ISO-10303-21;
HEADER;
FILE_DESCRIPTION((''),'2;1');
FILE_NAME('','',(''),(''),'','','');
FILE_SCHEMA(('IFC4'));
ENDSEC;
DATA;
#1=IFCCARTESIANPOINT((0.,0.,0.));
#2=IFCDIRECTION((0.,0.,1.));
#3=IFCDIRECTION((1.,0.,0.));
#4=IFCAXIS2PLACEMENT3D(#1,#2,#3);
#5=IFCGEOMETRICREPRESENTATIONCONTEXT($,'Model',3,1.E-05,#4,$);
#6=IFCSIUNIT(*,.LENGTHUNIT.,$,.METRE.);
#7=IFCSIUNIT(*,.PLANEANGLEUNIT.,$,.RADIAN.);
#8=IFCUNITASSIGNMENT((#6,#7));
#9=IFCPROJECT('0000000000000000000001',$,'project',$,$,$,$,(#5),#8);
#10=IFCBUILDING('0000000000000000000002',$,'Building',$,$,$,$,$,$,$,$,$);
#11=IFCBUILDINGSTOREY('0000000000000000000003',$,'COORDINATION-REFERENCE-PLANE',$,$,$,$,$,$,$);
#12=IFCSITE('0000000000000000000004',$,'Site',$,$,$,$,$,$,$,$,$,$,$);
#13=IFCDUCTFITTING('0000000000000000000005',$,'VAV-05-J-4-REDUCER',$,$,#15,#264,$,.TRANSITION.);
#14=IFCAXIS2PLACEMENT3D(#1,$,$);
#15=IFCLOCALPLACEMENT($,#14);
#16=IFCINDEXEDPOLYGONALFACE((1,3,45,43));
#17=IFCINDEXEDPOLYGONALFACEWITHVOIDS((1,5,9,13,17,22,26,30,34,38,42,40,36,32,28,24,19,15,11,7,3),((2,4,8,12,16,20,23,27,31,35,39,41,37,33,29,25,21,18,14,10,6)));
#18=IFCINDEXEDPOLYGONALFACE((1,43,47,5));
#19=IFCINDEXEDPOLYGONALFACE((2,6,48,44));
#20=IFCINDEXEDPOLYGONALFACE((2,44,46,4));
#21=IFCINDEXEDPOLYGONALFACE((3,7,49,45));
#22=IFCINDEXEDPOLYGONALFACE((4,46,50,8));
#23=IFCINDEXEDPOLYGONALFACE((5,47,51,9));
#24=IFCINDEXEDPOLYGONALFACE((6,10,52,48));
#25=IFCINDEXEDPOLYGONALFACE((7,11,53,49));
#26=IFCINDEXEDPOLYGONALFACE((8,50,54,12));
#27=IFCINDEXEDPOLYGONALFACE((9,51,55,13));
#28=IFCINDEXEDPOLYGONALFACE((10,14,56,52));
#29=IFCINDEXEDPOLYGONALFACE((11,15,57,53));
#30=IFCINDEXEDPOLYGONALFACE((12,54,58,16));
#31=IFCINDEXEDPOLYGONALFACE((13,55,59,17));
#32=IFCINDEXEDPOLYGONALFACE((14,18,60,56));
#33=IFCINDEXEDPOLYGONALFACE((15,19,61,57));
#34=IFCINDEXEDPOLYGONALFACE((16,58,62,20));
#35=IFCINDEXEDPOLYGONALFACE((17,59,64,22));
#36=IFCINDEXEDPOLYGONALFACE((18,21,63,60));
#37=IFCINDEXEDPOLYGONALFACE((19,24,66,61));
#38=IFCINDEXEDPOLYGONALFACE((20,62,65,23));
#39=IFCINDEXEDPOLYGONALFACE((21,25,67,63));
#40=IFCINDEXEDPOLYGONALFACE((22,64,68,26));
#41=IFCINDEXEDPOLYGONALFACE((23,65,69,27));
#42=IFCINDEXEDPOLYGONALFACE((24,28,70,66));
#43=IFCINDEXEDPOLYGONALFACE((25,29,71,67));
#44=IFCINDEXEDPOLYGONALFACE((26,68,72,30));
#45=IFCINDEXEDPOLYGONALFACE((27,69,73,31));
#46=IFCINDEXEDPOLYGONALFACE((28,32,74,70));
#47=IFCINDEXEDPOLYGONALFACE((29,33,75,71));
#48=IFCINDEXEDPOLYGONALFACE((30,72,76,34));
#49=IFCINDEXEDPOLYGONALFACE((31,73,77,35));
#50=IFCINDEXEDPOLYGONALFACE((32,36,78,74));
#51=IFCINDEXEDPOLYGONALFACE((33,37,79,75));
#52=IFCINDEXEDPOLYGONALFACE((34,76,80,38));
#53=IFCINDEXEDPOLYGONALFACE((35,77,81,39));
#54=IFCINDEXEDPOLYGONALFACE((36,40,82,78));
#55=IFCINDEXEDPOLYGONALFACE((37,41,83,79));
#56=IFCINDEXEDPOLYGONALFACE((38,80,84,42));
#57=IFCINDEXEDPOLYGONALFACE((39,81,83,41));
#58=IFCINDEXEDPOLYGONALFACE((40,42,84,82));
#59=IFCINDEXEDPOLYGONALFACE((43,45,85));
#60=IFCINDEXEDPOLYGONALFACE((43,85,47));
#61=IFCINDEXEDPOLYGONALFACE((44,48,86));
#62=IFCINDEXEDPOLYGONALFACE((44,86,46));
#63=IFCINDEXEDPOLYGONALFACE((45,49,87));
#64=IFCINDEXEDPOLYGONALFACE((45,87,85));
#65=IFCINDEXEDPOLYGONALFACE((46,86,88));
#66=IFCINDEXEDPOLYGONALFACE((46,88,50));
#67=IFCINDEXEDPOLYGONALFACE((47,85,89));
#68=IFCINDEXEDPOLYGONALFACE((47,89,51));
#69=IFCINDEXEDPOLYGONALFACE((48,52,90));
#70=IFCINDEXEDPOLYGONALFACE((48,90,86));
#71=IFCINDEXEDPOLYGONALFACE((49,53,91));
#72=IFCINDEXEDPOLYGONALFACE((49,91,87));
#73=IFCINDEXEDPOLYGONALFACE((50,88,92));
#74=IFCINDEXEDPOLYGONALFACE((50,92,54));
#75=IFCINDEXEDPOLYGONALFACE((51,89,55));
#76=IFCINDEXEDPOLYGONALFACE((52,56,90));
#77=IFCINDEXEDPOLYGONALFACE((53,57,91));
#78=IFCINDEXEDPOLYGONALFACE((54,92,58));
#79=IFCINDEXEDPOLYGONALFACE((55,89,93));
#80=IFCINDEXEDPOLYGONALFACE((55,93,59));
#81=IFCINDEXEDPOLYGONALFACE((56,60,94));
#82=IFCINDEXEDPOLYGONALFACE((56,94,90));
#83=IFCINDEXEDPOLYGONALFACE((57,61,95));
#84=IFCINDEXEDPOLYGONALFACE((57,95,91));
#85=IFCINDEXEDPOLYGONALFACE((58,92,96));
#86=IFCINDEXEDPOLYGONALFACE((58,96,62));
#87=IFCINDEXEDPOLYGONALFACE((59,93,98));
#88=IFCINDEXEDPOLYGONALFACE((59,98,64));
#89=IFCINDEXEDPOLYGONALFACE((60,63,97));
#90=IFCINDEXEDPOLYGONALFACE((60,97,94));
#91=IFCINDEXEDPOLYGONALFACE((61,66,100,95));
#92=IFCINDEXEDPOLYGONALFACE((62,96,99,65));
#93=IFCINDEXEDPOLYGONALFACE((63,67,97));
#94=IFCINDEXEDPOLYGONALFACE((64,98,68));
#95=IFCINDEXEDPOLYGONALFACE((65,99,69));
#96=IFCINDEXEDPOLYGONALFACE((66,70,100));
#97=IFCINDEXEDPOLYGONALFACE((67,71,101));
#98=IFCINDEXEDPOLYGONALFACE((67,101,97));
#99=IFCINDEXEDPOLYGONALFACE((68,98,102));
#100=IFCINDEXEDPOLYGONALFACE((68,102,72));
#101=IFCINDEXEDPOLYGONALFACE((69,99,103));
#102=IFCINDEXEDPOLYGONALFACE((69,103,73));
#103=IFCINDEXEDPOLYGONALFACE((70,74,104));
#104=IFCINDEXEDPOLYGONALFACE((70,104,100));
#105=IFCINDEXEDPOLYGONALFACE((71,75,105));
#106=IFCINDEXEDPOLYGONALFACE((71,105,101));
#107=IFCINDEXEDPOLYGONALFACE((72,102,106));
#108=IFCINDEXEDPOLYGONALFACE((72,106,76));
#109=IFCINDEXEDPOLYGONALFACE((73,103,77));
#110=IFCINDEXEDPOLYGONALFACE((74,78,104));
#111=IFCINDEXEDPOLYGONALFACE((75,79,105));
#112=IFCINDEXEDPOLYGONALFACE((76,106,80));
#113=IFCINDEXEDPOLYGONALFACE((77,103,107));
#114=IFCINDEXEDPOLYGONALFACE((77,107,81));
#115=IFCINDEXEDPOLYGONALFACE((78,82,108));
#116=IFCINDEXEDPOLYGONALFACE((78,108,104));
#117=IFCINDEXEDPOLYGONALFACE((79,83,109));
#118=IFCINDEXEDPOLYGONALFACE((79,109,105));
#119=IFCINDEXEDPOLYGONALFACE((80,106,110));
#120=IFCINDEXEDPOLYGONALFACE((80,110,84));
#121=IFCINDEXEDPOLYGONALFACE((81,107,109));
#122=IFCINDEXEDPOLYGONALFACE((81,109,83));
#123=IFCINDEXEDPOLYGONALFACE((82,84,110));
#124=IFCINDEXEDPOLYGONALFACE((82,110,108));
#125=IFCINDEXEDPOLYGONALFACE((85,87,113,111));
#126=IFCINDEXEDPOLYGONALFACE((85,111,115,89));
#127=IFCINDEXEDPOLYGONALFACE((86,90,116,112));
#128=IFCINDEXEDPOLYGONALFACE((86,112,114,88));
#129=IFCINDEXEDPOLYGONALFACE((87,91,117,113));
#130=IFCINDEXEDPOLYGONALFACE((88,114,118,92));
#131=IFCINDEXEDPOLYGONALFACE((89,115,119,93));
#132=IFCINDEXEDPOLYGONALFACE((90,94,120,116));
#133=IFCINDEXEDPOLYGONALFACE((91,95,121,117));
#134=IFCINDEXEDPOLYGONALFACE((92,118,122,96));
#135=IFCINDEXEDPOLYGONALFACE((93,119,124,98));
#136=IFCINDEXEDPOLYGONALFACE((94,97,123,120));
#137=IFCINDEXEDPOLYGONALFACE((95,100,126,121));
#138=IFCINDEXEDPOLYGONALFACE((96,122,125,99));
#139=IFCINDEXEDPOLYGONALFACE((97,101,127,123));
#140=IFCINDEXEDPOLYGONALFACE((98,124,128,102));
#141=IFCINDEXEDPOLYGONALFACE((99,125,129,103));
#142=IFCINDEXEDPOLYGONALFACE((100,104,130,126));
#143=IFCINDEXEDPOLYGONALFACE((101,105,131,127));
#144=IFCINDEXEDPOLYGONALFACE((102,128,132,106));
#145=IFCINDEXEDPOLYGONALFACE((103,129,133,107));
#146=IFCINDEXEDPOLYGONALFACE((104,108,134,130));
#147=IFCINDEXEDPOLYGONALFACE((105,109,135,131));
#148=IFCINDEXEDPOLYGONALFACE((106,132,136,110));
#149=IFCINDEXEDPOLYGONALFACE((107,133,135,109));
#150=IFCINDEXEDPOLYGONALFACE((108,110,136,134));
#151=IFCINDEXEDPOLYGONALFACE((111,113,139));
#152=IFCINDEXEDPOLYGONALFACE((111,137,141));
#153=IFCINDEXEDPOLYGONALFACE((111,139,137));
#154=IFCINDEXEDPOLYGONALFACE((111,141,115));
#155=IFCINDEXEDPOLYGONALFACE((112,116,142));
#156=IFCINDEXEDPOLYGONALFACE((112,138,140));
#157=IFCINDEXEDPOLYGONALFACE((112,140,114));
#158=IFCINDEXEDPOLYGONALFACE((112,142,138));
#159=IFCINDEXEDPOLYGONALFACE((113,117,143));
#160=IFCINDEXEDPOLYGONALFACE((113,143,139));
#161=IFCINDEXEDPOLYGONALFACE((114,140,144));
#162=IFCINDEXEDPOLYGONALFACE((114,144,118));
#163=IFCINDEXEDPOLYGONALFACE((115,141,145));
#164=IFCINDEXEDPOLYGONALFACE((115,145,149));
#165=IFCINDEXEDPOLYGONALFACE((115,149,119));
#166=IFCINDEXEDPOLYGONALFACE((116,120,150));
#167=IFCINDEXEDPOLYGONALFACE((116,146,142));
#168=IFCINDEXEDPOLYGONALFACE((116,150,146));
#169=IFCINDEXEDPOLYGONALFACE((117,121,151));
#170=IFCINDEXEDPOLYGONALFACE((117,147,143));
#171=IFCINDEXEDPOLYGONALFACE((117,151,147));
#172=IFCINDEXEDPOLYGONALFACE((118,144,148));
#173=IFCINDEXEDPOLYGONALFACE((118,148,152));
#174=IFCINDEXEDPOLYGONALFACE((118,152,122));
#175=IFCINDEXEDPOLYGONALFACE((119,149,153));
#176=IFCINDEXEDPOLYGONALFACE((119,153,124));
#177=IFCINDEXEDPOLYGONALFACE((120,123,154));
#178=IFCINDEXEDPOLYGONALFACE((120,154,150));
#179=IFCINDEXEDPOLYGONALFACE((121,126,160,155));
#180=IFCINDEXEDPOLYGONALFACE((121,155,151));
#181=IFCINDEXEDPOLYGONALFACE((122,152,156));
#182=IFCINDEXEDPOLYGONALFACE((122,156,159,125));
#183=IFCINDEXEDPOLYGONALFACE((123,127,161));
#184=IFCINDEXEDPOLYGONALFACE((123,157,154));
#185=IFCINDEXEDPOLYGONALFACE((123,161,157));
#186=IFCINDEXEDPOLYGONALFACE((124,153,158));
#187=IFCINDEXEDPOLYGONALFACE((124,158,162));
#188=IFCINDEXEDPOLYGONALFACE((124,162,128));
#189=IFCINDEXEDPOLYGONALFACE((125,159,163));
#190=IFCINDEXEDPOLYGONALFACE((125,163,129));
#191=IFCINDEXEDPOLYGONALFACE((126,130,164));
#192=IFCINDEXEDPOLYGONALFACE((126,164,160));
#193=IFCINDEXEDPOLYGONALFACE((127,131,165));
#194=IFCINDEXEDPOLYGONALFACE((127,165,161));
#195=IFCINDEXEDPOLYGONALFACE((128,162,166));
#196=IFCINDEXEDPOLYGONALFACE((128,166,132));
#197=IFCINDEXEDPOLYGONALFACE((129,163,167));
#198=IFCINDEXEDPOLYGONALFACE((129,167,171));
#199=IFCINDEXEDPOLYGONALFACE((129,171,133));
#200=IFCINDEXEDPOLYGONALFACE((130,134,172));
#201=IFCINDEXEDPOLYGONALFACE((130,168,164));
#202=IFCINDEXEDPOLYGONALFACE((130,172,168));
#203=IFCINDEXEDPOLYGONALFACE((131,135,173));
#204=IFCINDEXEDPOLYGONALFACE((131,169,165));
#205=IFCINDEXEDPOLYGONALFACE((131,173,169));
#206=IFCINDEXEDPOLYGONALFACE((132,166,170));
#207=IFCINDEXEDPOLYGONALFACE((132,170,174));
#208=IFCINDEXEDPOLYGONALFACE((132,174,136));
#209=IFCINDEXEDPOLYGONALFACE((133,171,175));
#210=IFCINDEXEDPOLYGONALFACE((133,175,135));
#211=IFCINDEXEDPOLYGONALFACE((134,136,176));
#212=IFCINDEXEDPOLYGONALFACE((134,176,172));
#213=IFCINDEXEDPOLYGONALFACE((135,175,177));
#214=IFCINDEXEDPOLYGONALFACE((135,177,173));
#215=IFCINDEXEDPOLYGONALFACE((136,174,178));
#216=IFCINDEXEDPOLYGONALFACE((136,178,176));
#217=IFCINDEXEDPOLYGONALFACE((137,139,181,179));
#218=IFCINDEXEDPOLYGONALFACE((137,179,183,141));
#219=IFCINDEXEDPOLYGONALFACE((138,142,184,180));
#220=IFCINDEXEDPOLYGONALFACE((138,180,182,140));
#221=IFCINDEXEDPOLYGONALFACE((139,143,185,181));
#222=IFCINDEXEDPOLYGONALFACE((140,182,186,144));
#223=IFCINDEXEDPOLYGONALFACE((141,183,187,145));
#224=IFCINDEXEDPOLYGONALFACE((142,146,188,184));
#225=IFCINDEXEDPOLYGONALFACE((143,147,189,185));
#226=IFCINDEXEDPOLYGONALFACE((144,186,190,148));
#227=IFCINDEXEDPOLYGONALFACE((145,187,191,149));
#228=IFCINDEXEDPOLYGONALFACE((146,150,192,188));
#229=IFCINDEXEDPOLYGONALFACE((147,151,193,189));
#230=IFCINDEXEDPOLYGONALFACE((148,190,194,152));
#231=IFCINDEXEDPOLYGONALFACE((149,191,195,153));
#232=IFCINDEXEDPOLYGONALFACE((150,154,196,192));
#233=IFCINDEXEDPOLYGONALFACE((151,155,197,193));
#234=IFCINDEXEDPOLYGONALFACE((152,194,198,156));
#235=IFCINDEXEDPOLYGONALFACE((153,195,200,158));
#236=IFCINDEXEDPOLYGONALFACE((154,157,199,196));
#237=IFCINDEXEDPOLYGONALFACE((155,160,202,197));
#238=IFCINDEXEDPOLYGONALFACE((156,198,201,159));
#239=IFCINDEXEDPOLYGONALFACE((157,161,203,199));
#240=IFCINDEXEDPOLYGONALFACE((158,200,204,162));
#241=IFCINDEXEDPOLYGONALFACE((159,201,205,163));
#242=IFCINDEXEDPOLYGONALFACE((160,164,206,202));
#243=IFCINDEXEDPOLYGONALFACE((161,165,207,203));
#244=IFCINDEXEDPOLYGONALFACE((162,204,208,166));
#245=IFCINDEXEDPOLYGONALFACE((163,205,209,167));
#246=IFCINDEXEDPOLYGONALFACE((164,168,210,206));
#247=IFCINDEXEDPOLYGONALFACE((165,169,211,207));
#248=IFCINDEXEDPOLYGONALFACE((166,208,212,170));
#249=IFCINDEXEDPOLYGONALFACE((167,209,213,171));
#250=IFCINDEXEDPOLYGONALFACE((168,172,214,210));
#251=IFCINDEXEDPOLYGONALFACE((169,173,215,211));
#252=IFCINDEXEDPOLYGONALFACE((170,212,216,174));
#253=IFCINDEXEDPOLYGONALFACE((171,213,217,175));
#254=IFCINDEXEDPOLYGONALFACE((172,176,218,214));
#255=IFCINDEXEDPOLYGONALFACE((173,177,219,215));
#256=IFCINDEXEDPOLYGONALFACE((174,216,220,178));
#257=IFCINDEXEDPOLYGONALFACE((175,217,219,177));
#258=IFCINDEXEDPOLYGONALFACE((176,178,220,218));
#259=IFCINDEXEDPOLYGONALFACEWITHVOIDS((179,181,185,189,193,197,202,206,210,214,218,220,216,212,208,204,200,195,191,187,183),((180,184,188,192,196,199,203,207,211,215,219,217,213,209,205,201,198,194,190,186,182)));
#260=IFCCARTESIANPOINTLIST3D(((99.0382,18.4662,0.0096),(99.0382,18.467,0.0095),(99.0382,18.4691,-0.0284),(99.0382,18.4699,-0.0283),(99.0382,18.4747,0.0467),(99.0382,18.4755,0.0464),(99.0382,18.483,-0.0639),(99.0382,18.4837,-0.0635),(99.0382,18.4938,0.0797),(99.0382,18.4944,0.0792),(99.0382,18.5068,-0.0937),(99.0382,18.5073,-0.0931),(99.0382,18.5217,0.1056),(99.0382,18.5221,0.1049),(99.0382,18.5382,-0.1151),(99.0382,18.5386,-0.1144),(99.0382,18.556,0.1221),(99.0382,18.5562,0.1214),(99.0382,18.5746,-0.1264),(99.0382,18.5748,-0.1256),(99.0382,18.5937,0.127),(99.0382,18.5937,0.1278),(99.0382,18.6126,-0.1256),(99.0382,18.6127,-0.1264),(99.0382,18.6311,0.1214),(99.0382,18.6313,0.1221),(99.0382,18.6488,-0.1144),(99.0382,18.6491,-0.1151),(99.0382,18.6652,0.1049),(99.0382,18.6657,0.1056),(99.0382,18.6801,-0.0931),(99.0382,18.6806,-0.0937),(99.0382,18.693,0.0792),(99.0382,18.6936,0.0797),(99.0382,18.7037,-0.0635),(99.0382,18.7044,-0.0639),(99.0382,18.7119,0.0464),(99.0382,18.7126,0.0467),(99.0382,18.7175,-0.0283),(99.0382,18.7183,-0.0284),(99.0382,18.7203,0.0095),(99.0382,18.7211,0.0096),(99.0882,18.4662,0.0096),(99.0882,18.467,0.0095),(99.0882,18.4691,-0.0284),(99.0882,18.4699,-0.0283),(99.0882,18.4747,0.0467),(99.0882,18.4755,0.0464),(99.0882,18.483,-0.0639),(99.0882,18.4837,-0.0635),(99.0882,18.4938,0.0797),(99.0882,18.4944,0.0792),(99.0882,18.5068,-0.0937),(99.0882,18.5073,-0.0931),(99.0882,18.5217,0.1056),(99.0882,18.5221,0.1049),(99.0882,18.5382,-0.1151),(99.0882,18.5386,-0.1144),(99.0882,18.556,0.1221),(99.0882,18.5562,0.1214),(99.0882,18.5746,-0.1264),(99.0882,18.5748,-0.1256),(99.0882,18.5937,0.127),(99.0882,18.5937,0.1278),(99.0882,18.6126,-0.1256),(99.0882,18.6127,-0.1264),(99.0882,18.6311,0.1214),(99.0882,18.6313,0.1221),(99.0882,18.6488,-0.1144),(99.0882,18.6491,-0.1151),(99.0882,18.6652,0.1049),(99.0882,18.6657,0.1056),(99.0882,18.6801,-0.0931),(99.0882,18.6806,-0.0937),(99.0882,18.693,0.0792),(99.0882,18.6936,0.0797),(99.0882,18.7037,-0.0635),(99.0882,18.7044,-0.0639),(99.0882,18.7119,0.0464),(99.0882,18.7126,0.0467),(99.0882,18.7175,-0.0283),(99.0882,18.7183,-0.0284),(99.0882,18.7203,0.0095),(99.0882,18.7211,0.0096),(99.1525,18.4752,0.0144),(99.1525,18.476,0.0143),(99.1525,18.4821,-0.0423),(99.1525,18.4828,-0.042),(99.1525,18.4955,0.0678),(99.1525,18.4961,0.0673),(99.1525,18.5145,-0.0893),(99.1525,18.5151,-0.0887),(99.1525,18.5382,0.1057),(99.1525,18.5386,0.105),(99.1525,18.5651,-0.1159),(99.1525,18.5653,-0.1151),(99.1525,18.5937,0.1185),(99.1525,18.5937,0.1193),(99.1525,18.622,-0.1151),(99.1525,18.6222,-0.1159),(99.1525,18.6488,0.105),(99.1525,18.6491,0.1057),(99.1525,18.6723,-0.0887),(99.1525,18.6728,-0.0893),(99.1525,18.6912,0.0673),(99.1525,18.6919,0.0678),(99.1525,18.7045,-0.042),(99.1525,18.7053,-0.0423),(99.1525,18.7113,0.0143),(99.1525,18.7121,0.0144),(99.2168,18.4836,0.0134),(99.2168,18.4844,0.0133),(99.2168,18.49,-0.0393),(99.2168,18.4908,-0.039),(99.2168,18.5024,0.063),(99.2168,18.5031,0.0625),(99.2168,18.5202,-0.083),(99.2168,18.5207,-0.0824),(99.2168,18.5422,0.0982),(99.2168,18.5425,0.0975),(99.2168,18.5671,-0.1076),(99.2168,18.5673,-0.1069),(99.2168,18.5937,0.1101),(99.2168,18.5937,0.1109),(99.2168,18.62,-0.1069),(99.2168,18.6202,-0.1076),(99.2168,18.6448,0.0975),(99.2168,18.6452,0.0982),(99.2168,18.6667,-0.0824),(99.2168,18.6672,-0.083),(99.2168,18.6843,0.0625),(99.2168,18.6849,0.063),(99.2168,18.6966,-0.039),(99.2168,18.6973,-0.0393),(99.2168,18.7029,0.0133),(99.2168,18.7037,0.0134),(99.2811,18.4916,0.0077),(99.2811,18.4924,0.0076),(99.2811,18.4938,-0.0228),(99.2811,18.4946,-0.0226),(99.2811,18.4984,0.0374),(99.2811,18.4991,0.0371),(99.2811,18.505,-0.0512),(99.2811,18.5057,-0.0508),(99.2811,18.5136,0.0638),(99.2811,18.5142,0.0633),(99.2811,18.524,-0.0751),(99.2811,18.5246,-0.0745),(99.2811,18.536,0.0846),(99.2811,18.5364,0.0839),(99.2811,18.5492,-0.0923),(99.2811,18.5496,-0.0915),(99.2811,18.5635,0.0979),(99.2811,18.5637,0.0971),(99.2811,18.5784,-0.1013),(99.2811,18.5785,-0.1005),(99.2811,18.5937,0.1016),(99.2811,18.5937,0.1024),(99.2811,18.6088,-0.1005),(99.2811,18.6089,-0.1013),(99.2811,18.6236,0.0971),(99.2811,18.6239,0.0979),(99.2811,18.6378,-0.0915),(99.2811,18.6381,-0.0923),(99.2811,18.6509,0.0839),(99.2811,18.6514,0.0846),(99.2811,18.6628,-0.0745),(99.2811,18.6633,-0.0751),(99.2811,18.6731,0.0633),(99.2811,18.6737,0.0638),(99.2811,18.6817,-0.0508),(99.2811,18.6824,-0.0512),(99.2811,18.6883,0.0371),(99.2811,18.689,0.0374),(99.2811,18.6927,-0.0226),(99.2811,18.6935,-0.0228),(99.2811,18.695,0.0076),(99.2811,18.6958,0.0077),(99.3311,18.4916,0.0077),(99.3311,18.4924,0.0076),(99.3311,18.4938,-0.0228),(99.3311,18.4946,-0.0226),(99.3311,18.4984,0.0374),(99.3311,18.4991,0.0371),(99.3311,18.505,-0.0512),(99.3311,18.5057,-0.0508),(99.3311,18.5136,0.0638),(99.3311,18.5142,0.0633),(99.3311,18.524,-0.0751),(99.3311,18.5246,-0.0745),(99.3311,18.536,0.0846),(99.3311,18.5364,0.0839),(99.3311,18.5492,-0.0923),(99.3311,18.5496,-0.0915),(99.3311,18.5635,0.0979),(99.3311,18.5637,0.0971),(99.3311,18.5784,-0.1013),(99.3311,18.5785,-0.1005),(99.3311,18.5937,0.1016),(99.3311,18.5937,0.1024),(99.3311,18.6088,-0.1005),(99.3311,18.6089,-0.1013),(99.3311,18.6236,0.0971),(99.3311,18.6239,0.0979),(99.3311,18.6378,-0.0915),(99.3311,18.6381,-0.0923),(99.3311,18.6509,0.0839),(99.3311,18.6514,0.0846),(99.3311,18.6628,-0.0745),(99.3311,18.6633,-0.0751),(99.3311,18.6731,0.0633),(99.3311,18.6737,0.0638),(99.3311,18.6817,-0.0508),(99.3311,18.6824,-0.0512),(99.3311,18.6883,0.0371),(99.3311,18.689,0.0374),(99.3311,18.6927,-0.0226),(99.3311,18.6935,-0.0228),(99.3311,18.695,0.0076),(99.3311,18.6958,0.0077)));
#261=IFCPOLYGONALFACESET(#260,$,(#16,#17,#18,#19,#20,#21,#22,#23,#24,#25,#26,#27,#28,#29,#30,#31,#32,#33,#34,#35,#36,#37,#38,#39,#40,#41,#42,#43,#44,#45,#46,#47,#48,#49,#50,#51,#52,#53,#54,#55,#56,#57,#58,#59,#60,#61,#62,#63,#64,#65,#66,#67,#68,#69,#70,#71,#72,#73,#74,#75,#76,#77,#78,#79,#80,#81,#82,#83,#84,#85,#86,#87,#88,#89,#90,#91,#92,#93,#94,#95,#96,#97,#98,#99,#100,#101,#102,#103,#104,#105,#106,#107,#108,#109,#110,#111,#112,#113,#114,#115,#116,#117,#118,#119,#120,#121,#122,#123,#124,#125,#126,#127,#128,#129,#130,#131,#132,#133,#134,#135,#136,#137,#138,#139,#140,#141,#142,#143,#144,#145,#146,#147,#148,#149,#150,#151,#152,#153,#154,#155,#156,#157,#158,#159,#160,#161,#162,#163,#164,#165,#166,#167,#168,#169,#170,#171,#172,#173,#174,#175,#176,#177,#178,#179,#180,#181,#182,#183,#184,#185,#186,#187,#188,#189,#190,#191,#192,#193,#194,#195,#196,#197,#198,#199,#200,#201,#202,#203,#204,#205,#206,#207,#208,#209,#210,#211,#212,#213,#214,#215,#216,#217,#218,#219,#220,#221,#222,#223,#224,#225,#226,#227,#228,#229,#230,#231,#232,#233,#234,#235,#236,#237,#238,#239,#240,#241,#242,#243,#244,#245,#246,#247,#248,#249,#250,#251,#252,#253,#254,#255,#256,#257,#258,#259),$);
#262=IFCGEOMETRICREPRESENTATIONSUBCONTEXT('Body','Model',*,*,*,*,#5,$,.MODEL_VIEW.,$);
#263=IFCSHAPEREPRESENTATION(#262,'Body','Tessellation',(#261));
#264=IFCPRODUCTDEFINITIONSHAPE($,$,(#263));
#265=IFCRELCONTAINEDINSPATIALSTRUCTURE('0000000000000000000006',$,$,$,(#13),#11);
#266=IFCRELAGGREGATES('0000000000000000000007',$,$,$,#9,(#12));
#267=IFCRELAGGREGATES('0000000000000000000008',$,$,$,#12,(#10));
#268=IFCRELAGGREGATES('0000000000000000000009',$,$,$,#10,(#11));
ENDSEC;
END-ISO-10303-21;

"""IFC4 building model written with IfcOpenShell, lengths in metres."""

from ifc_helpers import new_model, entity, si_unit, frame, origin_with_axes, place, context, subcontext, project, spatial, element, save


model = new_model("IFC4")

# Units and contexts
model_context_1 = context("Model", 3, precision=1e-05, world=origin_with_axes())
body_context_1 = subcontext(model_context_1, "Body", "Model", "MODEL_VIEW")
ifc_project = project(units=[si_unit("LENGTHUNIT", "METRE"), si_unit("PLANEANGLEUNIT", "RADIAN")], contexts=[model_context_1])

# Site, building, storey
site = spatial("IfcSite", under=ifc_project, Name="Site")
building = spatial("IfcBuilding", under=site, Name="Building")
storey = spatial("IfcBuildingStorey", under=building, Name="COORDINATION-REFERENCE-PLANE")

# Duct fitting
for number, where, z_axis, x_axis, name in (
    (1, (99.0382, 18.5937, 0.0), (0.0, 1.0, 0.0), (0.0, 0.0, 1.0), "VAV-05-J-4-REDUCER"),
):
    element("IfcDuctFitting", number, at=place(None, frame(where, z_axis=z_axis, x_axis=x_axis)), inside=storey, Name=name, PredefinedType="TRANSITION", context=body_context_1, shape_type="SweptSolid", body=[
        entity("IfcRevolvedAreaSolid", entity("IfcArbitraryClosedProfileDef", "AREA", None, entity("IfcPolyline", [entity("IfcCartesianPoint", [0.1278, 0.0]), entity("IfcCartesianPoint", [0.1278, 0.05]), entity("IfcCartesianPoint", [0.1024, 0.2429]), entity("IfcCartesianPoint", [0.1024, 0.2929]), entity("IfcCartesianPoint", [0.1016, 0.2929]), entity("IfcCartesianPoint", [0.1016, 0.2429]), entity("IfcCartesianPoint", [0.127, 0.05]), entity("IfcCartesianPoint", [0.127, 0.0]), entity("IfcCartesianPoint", [0.1278, 0.0])])), entity("IfcAxis2Placement3D", entity("IfcCartesianPoint", [0.0, 0.0, 0.0])), entity("IfcAxis1Placement", entity("IfcCartesianPoint", [0.0, 0.0, 0.0]), entity("IfcDirection", [0.0, 1.0, 0.0])), 6.283185),
    ])

save(model, "model.ifc")
